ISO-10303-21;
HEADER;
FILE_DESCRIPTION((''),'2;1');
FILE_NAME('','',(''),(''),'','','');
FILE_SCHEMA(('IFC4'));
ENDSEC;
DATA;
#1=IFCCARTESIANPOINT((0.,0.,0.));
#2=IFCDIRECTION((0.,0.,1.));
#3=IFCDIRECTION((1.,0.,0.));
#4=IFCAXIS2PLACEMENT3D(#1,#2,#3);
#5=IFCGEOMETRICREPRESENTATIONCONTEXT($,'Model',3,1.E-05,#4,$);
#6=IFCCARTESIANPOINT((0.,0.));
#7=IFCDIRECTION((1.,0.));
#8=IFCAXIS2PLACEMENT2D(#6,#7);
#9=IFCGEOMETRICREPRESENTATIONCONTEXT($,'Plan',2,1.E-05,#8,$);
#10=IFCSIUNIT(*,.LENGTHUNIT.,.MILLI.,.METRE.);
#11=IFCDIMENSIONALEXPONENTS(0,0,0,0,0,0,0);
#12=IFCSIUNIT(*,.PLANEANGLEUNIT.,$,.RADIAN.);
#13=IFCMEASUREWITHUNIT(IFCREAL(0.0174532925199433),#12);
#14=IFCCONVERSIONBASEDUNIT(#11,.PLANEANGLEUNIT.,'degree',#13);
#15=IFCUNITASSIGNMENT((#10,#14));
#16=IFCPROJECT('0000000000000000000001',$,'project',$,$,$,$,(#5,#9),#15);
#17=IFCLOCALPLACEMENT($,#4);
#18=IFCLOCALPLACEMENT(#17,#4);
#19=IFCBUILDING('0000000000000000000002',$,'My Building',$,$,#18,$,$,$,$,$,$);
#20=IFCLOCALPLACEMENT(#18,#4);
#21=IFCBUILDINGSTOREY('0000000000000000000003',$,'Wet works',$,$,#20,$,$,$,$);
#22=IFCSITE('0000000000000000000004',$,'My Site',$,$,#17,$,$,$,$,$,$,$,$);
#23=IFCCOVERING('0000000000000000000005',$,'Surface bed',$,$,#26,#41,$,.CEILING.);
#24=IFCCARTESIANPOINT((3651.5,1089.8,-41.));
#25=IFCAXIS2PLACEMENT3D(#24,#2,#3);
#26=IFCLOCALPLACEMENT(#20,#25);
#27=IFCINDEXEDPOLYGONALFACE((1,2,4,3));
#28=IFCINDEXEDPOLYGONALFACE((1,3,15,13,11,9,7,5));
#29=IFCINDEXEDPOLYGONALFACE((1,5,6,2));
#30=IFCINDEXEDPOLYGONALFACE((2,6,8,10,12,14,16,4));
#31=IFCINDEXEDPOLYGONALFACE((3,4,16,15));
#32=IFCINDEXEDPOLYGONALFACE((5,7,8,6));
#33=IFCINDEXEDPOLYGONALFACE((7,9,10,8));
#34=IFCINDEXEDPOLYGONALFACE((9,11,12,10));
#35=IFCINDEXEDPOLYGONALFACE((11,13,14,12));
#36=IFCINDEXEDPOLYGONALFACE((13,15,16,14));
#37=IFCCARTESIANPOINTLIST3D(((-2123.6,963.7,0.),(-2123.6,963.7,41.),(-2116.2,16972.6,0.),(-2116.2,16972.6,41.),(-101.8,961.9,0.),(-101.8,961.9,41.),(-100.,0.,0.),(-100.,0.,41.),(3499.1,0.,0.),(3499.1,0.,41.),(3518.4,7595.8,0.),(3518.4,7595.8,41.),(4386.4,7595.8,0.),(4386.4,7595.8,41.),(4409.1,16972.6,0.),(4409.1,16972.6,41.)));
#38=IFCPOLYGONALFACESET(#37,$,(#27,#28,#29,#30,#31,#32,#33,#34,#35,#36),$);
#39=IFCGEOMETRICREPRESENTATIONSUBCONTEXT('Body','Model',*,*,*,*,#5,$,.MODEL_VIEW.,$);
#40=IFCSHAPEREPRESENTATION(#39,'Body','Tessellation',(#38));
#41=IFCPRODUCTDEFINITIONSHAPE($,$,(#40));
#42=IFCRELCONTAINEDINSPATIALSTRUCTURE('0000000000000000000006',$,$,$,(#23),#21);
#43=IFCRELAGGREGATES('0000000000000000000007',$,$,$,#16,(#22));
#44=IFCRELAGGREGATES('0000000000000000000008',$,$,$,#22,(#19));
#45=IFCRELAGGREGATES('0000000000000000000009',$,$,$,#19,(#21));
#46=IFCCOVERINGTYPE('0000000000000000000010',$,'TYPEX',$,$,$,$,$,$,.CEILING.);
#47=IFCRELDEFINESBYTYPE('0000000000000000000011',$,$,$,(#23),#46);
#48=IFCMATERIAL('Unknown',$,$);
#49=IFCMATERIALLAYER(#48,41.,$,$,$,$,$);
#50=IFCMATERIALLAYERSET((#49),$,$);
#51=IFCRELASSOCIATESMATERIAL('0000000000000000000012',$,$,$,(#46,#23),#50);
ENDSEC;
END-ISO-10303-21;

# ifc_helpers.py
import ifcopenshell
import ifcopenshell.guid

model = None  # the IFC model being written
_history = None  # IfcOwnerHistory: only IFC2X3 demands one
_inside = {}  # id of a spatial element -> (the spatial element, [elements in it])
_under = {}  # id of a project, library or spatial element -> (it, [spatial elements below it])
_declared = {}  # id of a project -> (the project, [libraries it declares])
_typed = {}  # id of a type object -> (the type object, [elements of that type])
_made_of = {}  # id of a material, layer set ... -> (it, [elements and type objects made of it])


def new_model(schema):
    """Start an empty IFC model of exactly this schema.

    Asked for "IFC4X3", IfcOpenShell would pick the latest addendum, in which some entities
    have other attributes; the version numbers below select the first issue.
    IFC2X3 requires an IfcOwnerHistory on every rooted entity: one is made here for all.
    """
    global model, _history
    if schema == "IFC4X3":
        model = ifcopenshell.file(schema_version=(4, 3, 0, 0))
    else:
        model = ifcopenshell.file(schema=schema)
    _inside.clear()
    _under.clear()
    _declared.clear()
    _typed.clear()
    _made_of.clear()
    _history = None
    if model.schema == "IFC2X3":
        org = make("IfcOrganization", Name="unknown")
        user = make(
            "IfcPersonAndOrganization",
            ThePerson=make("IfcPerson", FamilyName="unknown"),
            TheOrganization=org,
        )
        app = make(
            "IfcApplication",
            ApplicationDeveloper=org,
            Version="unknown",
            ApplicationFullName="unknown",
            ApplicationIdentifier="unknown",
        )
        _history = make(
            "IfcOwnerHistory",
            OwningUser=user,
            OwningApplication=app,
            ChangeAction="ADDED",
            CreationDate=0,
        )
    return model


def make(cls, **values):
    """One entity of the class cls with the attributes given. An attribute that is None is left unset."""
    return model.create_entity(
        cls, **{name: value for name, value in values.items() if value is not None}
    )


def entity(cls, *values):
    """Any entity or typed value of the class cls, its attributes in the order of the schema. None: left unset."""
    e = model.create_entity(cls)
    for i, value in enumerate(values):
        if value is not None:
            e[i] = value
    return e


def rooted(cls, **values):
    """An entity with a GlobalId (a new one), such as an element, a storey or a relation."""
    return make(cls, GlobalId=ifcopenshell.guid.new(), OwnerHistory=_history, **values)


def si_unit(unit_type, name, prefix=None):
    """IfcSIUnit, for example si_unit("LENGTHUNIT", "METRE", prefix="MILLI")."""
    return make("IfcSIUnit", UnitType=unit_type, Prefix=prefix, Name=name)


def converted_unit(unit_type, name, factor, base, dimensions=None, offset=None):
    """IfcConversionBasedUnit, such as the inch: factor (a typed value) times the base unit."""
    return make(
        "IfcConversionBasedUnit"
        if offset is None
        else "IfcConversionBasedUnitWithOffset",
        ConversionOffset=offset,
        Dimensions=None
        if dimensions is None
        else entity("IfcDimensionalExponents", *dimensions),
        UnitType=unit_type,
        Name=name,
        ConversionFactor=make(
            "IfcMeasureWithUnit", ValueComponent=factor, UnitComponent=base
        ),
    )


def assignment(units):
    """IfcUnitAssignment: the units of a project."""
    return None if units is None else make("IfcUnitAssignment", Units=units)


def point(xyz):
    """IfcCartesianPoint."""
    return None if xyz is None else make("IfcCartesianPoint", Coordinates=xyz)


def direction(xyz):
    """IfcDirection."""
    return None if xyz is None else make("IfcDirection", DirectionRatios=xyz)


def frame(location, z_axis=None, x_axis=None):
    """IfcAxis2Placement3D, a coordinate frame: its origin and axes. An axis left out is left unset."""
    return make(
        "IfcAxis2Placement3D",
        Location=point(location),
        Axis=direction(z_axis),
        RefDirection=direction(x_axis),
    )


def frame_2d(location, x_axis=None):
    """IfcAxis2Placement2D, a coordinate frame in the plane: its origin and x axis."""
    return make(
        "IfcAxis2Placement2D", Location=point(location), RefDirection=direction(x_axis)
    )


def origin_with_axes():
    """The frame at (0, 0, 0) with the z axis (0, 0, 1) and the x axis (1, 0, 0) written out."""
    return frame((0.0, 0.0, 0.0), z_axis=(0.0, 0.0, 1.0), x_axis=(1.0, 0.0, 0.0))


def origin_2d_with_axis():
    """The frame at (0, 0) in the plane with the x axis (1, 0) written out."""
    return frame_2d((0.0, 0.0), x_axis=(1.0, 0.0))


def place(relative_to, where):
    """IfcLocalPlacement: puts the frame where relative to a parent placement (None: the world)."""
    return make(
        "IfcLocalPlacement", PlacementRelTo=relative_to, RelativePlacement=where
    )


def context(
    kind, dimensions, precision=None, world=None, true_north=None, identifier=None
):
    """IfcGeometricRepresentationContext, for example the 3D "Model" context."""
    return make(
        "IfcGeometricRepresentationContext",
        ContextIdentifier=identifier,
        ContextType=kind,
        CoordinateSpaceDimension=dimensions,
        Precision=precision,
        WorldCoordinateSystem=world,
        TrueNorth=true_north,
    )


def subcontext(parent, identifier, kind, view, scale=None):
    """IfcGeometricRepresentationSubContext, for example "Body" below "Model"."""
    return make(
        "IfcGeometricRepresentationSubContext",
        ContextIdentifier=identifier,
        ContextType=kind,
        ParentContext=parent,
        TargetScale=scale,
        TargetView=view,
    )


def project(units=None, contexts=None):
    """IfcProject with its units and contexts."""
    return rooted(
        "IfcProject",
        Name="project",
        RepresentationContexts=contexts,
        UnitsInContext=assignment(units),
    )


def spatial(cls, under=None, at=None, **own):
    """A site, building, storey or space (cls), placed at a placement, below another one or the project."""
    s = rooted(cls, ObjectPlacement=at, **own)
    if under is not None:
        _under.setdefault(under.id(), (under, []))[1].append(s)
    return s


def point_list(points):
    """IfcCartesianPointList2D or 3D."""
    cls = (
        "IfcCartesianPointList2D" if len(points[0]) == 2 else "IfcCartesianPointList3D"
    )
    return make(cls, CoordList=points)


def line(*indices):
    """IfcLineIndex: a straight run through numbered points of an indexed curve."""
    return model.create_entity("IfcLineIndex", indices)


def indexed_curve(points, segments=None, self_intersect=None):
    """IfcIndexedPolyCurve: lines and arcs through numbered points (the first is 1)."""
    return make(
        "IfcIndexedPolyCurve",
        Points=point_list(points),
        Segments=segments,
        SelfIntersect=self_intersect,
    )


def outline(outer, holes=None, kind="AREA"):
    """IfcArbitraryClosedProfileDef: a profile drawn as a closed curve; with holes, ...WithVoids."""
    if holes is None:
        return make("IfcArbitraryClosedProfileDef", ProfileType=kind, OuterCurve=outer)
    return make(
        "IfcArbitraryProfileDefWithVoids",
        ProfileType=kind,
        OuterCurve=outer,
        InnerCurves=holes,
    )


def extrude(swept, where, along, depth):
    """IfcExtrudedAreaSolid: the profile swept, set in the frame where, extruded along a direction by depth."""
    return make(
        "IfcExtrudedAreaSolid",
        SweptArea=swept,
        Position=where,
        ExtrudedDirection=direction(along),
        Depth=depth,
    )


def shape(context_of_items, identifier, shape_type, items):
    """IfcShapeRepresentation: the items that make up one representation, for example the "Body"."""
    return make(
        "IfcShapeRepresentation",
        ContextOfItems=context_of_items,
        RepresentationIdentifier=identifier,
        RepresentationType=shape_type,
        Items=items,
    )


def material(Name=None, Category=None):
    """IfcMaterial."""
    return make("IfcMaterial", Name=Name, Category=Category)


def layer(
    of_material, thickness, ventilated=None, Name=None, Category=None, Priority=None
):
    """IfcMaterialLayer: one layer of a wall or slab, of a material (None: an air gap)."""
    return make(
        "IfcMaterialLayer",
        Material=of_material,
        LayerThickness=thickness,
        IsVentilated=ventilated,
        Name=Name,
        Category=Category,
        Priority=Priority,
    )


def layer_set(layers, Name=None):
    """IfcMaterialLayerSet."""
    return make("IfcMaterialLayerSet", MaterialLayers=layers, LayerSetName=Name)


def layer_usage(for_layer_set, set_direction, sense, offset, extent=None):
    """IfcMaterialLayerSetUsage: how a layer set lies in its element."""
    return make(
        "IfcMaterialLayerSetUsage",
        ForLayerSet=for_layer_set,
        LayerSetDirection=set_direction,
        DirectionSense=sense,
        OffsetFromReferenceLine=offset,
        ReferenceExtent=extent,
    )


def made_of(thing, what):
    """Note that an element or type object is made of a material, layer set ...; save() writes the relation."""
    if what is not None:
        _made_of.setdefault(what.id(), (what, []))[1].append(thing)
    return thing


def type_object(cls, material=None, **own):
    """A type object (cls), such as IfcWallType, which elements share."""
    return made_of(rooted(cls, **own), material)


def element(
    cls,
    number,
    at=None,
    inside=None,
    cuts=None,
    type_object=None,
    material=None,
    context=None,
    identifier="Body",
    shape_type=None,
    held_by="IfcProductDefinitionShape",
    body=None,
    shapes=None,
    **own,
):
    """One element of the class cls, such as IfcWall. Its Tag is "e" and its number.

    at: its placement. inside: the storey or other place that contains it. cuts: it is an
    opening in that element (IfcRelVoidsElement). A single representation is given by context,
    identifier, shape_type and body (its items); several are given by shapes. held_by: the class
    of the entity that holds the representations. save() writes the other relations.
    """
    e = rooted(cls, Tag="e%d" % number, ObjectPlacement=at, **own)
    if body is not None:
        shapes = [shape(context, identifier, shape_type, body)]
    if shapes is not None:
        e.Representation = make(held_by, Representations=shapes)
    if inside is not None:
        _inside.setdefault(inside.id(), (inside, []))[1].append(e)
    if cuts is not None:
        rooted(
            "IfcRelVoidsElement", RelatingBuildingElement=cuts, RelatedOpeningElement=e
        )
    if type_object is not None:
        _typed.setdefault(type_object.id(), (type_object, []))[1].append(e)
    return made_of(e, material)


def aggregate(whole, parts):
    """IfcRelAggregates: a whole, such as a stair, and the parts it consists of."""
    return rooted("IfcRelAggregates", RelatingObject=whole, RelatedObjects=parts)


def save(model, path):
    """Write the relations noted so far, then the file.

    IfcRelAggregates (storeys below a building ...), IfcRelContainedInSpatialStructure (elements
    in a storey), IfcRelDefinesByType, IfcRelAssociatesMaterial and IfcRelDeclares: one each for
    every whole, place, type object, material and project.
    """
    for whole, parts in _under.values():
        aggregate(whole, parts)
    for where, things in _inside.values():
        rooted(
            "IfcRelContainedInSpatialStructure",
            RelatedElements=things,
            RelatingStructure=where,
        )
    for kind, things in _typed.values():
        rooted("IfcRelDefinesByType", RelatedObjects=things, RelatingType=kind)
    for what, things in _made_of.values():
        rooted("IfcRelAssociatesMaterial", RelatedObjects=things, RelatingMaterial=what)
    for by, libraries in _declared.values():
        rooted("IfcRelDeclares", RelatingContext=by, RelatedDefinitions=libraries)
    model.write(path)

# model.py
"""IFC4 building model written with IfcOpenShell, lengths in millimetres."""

from ifc_helpers import new_model, entity, si_unit, converted_unit, frame, origin_with_axes, origin_2d_with_axis, place, context, subcontext, project, spatial, line, indexed_curve, outline, extrude, material, layer, layer_set, layer_usage, type_object, element, save


model = new_model("IFC4")

# Units and contexts
model_context = context("Model", 3, precision=1e-05, world=origin_with_axes())
plan_context = context("Plan", 2, precision=1e-05, world=origin_2d_with_axis())
body_context_1 = subcontext(model_context, "Body", "Model", "MODEL_VIEW")
ifc_project = project(units=[si_unit("LENGTHUNIT", "METRE", prefix="MILLI"), converted_unit("PLANEANGLEUNIT", "degree", entity("IfcReal", 0.0174532925199433), si_unit("PLANEANGLEUNIT", "RADIAN"), dimensions=[0, 0, 0, 0, 0, 0, 0])], contexts=[model_context, plan_context])

# Site, building, storey
site_placement = place(None, origin_with_axes())
site = spatial("IfcSite", under=ifc_project, at=site_placement, Name="My Site")
building_placement = place(site_placement, origin_with_axes())
building = spatial("IfcBuilding", under=site, at=building_placement, Name="My Building")
storey_placement = place(building_placement, origin_with_axes())
storey = spatial("IfcBuildingStorey", under=building, at=storey_placement, Name="Wet works")

# Shared definitions
ifc_material_1 = material(Name="Unknown")

# Covering
ifc_layer_1 = layer(ifc_material_1, 41.0)
ifc_layer_set_1 = layer_set([ifc_layer_1])
ifc_layer_usage_1 = layer_usage(ifc_layer_set_1, "AXIS3", "POSITIVE", 0.0)
covering_type = type_object("IfcCoveringType", Name="TYPEX", PredefinedType="CEILING", material=ifc_layer_set_1)
covering_placement = place(storey_placement, frame((3651.5, 1089.8, -41.0), z_axis=(0.0, 0.0, 1.0), x_axis=(1.0, 0.0, 0.0)))
element("IfcCovering", 1, at=covering_placement, inside=storey, type_object=covering_type, material=ifc_layer_usage_1, Name="Surface bed", PredefinedType="CEILING", context=body_context_1, shape_type="SweptSolid", body=[
    extrude(outline(indexed_curve([(4386.4, 7595.8), (4409.1, 16972.6), (-2116.2, 16972.6), (-2123.6, 963.7), (-101.8, 961.9), (-100.0, 0.0), (3499.1, 0.0), (3518.4, 7595.8)], segments=[line(3, 2), line(2, 1), line(1, 8), line(8, 7), line(7, 6), line(6, 5), line(5, 4), line(4, 3)], self_intersect=False)), None, (0.0, 0.0, 1.0), 41.0),
])

save(model, "model.ifc")
